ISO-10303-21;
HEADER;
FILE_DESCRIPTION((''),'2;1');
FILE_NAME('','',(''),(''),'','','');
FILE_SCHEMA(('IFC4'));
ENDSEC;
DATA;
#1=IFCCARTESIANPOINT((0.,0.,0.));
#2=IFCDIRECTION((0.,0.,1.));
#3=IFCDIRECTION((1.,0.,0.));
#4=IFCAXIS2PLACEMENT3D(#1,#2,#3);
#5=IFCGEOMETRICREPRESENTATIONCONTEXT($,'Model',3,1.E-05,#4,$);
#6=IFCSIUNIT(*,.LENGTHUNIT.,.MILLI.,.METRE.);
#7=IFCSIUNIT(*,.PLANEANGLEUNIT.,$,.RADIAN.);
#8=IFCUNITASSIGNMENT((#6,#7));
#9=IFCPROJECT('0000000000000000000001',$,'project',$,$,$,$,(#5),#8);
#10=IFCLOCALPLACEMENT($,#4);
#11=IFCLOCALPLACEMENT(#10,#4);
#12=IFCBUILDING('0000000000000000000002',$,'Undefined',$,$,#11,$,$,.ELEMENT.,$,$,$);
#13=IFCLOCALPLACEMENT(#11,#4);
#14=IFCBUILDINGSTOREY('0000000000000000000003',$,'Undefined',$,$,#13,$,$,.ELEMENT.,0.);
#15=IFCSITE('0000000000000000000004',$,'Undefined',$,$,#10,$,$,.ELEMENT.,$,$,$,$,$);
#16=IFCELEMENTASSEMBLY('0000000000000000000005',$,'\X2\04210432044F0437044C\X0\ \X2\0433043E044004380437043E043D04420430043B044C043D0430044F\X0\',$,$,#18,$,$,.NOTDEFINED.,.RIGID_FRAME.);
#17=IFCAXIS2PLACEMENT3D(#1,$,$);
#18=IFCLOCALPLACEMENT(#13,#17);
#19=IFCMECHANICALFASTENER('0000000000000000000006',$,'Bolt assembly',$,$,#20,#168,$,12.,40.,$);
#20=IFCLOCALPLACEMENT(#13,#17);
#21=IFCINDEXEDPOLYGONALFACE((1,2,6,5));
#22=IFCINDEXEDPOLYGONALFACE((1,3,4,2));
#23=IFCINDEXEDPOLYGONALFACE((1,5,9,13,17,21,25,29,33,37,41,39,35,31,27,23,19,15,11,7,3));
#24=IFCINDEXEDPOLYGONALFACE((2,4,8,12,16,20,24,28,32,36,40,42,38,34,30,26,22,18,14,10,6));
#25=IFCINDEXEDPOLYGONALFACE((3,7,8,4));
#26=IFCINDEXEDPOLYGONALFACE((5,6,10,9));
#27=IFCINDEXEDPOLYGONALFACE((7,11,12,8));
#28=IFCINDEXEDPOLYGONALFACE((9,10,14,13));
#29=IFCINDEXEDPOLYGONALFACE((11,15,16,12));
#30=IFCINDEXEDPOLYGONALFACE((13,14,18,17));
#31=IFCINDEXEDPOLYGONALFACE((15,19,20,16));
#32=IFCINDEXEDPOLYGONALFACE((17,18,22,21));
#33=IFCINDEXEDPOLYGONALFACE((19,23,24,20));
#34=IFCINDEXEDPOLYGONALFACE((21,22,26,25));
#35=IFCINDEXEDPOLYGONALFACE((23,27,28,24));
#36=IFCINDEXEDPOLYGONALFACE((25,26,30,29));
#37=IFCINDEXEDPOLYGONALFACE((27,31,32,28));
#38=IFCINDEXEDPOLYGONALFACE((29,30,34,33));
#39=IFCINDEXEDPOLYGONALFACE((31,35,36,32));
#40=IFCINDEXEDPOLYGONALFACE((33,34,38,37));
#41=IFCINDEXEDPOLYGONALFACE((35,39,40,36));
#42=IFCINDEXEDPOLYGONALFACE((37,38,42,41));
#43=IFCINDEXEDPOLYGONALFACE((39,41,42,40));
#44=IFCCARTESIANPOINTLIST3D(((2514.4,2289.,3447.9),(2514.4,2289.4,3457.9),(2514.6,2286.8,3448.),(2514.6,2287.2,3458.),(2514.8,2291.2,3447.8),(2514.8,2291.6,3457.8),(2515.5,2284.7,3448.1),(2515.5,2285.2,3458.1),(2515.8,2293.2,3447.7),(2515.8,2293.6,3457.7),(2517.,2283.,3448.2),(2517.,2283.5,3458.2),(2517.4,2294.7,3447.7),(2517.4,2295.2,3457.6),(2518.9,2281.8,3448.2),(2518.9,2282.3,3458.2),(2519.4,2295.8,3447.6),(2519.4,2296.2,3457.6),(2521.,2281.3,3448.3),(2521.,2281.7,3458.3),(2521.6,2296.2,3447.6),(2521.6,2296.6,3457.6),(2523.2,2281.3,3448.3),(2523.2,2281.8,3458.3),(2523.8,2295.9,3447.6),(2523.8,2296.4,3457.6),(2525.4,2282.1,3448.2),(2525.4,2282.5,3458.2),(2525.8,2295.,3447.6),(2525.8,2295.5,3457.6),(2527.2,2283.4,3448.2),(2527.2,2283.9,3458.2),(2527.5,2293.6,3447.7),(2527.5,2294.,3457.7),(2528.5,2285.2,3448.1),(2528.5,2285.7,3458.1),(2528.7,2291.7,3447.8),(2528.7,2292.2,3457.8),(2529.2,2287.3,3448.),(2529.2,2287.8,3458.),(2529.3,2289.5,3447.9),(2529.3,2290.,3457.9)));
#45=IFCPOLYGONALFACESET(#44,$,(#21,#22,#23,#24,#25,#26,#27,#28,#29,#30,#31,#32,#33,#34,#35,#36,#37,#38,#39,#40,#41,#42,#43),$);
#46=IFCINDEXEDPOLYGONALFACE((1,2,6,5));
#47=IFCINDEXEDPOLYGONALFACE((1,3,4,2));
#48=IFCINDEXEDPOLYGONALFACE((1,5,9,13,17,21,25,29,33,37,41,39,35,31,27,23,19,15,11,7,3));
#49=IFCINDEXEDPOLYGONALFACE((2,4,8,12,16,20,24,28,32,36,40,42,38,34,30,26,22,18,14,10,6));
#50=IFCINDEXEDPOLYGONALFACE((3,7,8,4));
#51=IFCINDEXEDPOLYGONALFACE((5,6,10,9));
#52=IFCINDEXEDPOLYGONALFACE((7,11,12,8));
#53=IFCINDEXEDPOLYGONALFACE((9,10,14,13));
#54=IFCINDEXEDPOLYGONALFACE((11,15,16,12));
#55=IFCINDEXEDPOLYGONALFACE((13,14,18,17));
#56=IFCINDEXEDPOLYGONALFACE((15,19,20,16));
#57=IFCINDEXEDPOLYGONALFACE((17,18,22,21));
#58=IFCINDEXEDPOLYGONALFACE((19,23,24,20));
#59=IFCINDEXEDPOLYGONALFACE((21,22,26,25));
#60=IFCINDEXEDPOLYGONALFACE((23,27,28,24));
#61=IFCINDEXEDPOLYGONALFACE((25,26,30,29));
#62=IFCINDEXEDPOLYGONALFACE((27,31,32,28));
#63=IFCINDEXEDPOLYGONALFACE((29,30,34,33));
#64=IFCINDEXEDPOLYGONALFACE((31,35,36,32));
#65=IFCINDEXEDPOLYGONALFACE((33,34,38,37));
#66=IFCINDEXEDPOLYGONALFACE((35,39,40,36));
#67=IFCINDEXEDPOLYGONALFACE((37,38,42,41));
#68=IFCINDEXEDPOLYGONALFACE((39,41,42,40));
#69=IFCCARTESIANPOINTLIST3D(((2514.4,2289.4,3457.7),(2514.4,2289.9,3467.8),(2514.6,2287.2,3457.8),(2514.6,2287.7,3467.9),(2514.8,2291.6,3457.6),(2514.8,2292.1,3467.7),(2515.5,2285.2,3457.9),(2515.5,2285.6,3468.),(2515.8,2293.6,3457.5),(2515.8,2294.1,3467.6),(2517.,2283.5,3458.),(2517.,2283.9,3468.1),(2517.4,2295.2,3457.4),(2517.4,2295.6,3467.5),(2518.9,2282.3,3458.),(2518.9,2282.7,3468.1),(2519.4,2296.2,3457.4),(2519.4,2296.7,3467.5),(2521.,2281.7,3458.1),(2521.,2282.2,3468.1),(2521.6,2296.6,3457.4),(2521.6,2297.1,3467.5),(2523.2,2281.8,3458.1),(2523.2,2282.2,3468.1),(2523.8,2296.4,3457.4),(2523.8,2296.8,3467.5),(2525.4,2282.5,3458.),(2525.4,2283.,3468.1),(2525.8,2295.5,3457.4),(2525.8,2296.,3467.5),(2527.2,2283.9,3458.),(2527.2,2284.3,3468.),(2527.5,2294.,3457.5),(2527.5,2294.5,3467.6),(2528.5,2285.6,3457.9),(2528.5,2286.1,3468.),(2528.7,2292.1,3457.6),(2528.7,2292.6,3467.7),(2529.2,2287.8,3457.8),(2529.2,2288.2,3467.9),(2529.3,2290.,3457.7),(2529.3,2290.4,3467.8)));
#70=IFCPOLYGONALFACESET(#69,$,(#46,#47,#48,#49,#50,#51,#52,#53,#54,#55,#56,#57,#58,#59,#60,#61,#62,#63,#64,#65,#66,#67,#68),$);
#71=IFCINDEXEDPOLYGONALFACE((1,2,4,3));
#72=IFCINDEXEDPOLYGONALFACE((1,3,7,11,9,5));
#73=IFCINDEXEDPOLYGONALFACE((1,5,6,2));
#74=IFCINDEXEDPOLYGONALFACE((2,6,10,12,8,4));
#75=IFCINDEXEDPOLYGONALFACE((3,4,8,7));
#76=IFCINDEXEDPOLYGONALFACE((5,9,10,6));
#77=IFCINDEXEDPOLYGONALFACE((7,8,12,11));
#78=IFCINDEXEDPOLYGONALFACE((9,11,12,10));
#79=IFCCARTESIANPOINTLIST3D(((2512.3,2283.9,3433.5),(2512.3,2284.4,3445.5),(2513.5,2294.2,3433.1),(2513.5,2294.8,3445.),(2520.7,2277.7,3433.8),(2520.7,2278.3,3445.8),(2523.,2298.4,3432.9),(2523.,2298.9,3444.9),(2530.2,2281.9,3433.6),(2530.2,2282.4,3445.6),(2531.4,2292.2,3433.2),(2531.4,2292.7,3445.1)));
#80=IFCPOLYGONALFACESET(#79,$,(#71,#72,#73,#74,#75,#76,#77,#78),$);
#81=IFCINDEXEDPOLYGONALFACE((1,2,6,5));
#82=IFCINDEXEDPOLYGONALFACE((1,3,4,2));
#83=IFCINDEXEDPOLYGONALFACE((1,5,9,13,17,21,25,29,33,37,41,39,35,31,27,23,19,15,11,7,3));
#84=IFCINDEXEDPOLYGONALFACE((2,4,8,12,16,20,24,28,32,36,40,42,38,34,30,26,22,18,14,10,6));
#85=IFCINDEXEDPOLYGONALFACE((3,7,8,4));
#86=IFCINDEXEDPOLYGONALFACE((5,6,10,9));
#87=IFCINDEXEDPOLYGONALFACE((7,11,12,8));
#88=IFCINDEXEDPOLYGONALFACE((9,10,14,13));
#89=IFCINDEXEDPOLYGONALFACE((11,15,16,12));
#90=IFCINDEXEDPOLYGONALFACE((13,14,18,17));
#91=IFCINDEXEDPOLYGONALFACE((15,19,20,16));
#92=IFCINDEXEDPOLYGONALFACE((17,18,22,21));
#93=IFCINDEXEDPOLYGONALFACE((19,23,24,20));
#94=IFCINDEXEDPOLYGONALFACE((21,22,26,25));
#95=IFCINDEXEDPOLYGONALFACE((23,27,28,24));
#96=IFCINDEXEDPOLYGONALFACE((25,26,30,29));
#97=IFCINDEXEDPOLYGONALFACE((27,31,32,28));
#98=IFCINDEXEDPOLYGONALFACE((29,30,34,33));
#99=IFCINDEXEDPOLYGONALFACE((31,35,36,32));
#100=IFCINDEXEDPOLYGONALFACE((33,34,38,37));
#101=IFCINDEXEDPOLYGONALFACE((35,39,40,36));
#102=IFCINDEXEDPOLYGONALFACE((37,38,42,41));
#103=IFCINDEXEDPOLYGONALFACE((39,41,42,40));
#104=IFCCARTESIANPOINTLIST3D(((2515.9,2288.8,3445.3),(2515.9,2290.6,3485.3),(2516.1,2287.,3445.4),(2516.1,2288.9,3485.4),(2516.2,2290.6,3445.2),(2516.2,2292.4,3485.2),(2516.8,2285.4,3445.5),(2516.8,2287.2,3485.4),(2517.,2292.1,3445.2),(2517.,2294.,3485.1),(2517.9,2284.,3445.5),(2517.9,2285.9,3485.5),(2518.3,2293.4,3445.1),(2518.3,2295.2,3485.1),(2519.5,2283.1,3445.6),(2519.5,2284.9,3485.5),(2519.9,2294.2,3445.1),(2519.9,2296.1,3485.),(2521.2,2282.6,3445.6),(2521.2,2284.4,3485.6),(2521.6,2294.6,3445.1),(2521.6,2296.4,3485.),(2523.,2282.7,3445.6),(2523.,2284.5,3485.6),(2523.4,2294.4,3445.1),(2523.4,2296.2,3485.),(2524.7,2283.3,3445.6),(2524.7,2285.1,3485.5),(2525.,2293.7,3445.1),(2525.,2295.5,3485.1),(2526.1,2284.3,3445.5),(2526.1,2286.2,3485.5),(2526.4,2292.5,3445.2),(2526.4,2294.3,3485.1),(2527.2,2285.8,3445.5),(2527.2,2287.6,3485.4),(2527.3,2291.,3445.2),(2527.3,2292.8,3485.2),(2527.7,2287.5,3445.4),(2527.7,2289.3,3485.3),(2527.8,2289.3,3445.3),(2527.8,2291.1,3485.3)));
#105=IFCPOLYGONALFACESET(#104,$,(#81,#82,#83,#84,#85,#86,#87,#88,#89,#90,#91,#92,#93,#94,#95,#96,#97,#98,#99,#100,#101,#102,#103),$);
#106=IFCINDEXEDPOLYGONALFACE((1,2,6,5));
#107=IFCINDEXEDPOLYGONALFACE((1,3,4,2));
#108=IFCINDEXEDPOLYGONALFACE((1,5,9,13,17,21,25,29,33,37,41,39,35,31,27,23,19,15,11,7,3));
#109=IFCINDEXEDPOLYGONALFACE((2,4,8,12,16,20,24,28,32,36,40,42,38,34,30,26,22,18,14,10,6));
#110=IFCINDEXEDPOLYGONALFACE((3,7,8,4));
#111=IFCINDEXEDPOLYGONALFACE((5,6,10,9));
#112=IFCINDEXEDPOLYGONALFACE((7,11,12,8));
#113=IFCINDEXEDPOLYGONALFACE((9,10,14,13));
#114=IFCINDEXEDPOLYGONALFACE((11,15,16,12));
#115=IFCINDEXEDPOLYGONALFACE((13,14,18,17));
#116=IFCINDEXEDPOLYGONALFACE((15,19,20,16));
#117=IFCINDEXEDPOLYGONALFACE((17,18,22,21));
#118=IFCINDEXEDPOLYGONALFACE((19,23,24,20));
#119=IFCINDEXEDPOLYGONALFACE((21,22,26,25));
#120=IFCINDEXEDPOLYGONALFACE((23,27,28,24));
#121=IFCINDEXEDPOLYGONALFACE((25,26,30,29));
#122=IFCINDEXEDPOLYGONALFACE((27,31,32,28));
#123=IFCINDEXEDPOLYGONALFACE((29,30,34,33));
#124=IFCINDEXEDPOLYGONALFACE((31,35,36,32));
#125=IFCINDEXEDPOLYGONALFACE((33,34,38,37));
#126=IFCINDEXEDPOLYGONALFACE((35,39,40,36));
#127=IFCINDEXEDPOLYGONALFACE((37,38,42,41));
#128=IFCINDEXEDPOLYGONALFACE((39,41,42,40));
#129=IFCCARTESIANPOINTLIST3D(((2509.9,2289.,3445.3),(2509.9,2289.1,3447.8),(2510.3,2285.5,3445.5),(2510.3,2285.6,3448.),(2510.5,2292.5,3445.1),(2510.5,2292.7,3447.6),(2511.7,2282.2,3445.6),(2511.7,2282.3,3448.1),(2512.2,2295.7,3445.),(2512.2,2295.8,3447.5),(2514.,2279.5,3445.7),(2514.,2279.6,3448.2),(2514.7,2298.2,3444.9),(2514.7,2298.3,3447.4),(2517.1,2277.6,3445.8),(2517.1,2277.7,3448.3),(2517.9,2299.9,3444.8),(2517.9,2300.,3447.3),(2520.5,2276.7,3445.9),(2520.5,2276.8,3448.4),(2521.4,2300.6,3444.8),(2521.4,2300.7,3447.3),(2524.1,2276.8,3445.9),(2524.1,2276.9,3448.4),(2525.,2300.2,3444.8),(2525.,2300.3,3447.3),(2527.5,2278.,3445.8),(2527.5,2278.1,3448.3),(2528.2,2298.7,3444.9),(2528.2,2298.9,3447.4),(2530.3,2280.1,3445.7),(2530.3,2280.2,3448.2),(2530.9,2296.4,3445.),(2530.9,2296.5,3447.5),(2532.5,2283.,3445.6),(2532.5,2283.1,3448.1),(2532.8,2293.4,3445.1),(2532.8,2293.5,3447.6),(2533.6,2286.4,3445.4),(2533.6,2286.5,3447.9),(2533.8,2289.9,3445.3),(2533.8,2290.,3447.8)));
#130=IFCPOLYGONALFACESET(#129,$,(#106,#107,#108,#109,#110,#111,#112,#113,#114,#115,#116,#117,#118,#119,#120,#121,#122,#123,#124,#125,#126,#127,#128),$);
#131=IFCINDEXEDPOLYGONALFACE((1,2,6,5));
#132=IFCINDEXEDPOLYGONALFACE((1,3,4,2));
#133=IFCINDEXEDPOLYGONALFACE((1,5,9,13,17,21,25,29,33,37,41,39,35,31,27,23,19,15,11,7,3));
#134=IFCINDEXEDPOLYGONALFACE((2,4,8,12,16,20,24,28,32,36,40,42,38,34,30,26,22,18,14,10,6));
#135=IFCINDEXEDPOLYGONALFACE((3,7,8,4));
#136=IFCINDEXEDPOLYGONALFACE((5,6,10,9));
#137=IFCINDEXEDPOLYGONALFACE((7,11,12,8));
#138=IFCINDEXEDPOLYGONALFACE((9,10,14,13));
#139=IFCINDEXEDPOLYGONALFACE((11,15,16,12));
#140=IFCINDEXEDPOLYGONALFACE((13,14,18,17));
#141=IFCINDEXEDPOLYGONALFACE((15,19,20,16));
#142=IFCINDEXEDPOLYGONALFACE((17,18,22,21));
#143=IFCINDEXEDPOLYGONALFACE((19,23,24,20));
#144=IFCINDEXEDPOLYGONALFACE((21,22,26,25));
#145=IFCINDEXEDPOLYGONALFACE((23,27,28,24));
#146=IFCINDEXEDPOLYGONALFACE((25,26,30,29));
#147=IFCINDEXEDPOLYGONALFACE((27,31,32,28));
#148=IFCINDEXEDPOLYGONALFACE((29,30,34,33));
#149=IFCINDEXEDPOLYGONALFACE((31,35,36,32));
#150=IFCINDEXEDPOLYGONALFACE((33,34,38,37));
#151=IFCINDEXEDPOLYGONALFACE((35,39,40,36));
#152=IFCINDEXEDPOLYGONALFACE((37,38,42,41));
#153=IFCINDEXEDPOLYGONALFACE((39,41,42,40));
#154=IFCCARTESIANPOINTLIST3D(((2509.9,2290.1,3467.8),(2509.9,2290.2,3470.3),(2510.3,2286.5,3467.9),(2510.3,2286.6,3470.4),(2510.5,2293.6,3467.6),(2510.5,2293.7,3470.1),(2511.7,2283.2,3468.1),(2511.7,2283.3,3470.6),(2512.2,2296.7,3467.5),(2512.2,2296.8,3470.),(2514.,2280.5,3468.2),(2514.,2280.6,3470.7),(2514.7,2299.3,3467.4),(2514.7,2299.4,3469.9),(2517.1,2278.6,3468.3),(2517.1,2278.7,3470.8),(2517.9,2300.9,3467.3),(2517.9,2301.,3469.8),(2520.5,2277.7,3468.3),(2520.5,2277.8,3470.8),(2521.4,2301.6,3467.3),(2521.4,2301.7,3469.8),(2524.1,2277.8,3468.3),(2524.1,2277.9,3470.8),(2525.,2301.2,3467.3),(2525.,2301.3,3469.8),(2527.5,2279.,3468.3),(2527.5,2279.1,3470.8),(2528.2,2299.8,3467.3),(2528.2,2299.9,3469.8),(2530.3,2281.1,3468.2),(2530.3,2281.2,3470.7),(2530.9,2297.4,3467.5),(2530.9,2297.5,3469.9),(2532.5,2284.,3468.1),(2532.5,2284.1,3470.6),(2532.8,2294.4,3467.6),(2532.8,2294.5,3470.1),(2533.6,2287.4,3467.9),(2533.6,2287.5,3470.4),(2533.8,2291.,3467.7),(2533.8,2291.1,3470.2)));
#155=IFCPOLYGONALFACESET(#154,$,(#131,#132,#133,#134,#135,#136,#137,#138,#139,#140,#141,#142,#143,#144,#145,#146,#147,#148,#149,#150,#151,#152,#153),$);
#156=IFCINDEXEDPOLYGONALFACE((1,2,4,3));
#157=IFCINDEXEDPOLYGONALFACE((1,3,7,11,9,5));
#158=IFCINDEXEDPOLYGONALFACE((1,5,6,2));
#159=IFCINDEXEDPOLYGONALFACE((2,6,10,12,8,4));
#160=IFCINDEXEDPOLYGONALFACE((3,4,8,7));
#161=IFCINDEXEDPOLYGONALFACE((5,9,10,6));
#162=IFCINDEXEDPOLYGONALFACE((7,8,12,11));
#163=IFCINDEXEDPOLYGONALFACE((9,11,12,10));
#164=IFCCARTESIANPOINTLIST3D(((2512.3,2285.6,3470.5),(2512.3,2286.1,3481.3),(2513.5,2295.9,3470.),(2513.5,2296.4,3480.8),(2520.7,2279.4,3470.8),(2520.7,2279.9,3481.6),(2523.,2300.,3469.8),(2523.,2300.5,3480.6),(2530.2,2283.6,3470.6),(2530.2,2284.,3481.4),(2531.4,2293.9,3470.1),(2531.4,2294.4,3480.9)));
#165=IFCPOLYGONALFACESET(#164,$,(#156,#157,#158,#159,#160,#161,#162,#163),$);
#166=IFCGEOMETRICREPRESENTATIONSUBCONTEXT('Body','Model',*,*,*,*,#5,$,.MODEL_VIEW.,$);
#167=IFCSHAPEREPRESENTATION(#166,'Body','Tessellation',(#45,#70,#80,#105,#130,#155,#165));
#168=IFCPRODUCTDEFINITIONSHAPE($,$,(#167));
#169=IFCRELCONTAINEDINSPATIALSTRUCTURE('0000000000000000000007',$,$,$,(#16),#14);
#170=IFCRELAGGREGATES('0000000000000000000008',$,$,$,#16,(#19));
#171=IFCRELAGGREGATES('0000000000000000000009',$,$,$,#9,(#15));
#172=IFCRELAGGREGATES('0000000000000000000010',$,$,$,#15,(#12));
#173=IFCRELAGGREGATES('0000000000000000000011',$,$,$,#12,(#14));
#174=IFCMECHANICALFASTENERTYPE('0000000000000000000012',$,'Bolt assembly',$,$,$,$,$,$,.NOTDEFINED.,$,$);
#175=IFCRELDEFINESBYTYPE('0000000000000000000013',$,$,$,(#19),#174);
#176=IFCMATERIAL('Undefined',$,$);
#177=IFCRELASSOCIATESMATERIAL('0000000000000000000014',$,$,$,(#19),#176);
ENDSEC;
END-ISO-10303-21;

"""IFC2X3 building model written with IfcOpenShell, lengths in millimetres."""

from ifc_helpers import new_model, si_unit, frame, origin_with_axes, origin_2d_with_axis, place, context, subcontext, project, spatial, polyline, circle, outline, extrude, source, transform, mapped, material, type_object, element, aggregate, save


model = new_model("IFC2X3")

# Units and contexts
model_context = context("Model", 3, precision=1e-05, world=origin_with_axes())
body_context = subcontext(model_context, "Body", "Model", "MODEL_VIEW")
ifc_project = project(units=[si_unit("LENGTHUNIT", "METRE", prefix="MILLI"), si_unit("PLANEANGLEUNIT", "RADIAN")], contexts=[model_context])

# Site, building, storey
site_placement = place(None, origin_with_axes())
site = spatial("IfcSite", under=ifc_project, at=site_placement, Name="Undefined", CompositionType="ELEMENT")
building_placement = place(site_placement, origin_with_axes())
building = spatial("IfcBuilding", under=site, at=building_placement, Name="Undefined", CompositionType="ELEMENT")
storey_placement = place(building_placement, origin_with_axes())
storey = spatial("IfcBuildingStorey", under=building, at=storey_placement, Name="Undefined", CompositionType="ELEMENT", Elevation=0.0)

# Element assembly
assembly_1_placement = place(storey_placement, origin_with_axes())
assembly_1 = element("IfcElementAssembly", 1, at=assembly_1_placement, inside=storey, Name="Связь горизонтальная", AssemblyPlace="NOTDEFINED", PredefinedType="RIGID_FRAME")

# Mechanical fastener
ifc_material_1 = material(Name="Undefined")
mechanical_fastener_type = type_object("IfcMechanicalFastenerType", Name="Bolt assembly")
shared_shape_1 = source(origin_with_axes(), body_context, "Body", "SweptSolid", [
    extrude(circle(Radius=7.5, at=origin_2d_with_axis()), frame((0.0, 0.1, 0.0), z_axis=(0.0, 1.0, 0.0), x_axis=(1.0, 0.0, 0.0)), (0.0, 0.0, 1.0), 10.0),
    extrude(circle(Radius=7.5, at=origin_2d_with_axis()), frame((0.0, 9.9, 0.0), z_axis=(0.0, 1.0, 0.0), x_axis=(1.0, 0.0, 0.0)), (0.0, 0.0, 1.0), 10.1),
    extrude(outline(polyline([(10.4, 0.0), (5.2, 9.0), (-5.2, 9.0), (-10.4, 0.0), (-5.2, -9.0), (5.2, -9.0), (10.4, 0.0)])), frame((0.0, -14.5, 0.0), z_axis=(0.0, 1.0, 0.0), x_axis=(1.0, 0.0, 0.0)), (0.0, 0.0, 1.0), 12.0),
    extrude(circle(Radius=6.0, at=origin_2d_with_axis()), frame((0.0, -2.5, 0.0), z_axis=(0.0, 1.0, 0.0), x_axis=(1.0, 0.0, 0.0)), (0.0, 0.0, 1.0), 40.0),
    extrude(circle(Radius=12.0, at=origin_2d_with_axis()), frame((0.0, -2.5, 0.0), z_axis=(0.0, 1.0, 0.0), x_axis=(1.0, 0.0, 0.0)), (0.0, 0.0, 1.0), 2.5),
    extrude(circle(Radius=12.0, at=origin_2d_with_axis()), frame((0.0, 20.0, 0.0), z_axis=(0.0, 1.0, 0.0), x_axis=(1.0, 0.0, 0.0)), (0.0, 0.0, 1.0), 2.5),
    extrude(outline(polyline([(10.4, 0.0), (5.2, 9.0), (-5.2, 9.0), (-10.4, 0.0), (-5.2, -9.0), (5.2, -9.0), (10.4, 0.0)])), frame((0.0, 22.5, 0.0), z_axis=(0.0, 1.0, 0.0), x_axis=(1.0, 0.0, 0.0)), (0.0, 0.0, 1.0), 10.8),
])
mechanical_fastener_1_placement = place(assembly_1_placement, frame((2521.9, 2288.7, 3447.8), z_axis=(0.593795, 0.803786, -0.036536), x_axis=(-0.804616, 0.593183, -0.026963)))
mechanical_fastener_1 = element("IfcMechanicalFastener", 2, at=mechanical_fastener_1_placement, type_object=mechanical_fastener_type, material=ifc_material_1, Name="Bolt assembly", NominalDiameter=12.0, NominalLength=40.0, context=body_context, shape_type="MappedRepresentation", body=[
    mapped(shared_shape_1, transform((0.0, 0.0, 0.0))),
])
aggregate(assembly_1, [mechanical_fastener_1])

save(model, "model.ifc")
